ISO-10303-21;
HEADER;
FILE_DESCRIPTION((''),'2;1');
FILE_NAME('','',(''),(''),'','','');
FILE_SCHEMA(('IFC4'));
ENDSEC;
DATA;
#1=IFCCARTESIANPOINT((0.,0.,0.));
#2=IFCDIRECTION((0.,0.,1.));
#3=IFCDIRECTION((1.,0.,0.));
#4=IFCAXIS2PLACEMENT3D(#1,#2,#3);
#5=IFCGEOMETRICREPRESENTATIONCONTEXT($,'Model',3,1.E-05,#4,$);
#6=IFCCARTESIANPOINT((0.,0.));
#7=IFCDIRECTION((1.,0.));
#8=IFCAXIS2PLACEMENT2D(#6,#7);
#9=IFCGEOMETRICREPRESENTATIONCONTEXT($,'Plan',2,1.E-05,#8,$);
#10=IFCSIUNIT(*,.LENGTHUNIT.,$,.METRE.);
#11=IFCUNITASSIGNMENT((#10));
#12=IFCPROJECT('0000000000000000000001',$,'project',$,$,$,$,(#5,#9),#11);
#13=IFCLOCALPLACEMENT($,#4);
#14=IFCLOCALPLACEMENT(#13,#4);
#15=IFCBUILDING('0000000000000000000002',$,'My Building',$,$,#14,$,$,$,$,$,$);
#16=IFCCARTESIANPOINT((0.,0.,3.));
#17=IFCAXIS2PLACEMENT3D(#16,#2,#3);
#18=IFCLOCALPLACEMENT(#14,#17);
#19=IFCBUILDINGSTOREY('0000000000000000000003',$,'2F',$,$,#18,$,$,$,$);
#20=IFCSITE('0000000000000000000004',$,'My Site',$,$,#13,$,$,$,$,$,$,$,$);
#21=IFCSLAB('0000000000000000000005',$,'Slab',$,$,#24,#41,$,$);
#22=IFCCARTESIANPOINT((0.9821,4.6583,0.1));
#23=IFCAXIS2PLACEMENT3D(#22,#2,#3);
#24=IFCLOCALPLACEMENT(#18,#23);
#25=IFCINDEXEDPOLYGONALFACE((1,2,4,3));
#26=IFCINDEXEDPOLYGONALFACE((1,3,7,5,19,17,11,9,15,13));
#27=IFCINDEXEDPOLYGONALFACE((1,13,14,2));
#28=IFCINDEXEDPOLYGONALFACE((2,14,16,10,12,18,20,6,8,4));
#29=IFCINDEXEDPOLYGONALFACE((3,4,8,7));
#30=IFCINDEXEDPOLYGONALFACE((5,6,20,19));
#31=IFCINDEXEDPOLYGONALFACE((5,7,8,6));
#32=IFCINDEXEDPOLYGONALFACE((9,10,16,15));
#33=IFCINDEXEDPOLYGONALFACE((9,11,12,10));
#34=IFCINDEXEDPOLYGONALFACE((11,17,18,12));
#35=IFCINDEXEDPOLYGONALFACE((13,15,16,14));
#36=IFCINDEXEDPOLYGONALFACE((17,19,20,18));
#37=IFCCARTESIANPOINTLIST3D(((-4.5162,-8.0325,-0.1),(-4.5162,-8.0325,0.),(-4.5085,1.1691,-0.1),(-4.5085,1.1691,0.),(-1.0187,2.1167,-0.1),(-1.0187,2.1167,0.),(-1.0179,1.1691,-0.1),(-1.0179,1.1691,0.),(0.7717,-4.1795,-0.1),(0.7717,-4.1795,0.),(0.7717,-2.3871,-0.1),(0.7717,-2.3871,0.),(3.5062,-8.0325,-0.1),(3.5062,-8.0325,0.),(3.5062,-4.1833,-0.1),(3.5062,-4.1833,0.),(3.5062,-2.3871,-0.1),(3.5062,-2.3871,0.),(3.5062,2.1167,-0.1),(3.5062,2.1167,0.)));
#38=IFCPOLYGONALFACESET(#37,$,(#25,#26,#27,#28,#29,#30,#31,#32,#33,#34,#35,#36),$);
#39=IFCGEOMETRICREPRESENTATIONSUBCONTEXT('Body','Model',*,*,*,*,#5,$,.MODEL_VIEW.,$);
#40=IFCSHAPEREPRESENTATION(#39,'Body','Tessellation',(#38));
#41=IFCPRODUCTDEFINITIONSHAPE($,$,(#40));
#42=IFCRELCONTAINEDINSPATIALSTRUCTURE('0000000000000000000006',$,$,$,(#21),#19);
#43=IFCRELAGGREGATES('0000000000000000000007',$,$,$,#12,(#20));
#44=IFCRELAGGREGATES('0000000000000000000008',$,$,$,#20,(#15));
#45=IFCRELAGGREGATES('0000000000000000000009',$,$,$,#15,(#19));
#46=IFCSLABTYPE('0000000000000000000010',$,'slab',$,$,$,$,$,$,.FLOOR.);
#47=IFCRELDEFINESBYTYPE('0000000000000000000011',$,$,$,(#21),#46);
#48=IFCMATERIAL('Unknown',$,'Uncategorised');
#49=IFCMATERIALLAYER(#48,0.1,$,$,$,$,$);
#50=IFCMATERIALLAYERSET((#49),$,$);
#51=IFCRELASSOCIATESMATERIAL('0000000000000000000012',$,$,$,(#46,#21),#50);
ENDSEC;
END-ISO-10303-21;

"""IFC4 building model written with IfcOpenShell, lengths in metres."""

from ifc_helpers import new_model, si_unit, frame, origin_with_axes, origin_2d_with_axis, place, context, subcontext, project, spatial, indexed_curve, outline, extrude, material, layer, layer_set, layer_usage, type_object, element, save


model = new_model("IFC4")

# Units and contexts
model_context = context("Model", 3, precision=1e-05, world=origin_with_axes())
plan_context = context("Plan", 2, precision=1e-05, world=origin_2d_with_axis())
body_context_1 = subcontext(model_context, "Body", "Model", "MODEL_VIEW")
ifc_project = project(units=[si_unit("LENGTHUNIT", "METRE")], contexts=[model_context, plan_context])

# Site, building, storey
site_placement = place(None, origin_with_axes())
site = spatial("IfcSite", under=ifc_project, at=site_placement, Name="My Site")
building_placement = place(site_placement, origin_with_axes())
building = spatial("IfcBuilding", under=site, at=building_placement, Name="My Building")
storey_placement = place(building_placement, frame((0.0, 0.0, 3.0), z_axis=(0.0, 0.0, 1.0), x_axis=(1.0, 0.0, 0.0)))
storey = spatial("IfcBuildingStorey", under=building, at=storey_placement, Name="2F")

# Shared definitions
ifc_material = material(Name="Unknown", Category="Uncategorised")

# Slab
ifc_layer_1 = layer(ifc_material, 0.1)
ifc_layer_set_1 = layer_set([ifc_layer_1])
ifc_layer_usage_1 = layer_usage(ifc_layer_set_1, "AXIS3", "POSITIVE", -0.1)
slab_type = type_object("IfcSlabType", Name="slab", PredefinedType="FLOOR", material=ifc_layer_set_1)
slab_placement = place(storey_placement, frame((0.9821, 4.6583, 0.1), z_axis=(0.0, 0.0, 1.0), x_axis=(1.0, 0.0, 0.0)))
element("IfcSlab", 1, at=slab_placement, inside=storey, type_object=slab_type, material=ifc_layer_usage_1, Name="Slab", context=body_context_1, shape_type="SweptSolid", body=[
    extrude(outline(indexed_curve([(-1.0187, 2.1167), (-1.0179, 1.1691), (-4.5085, 1.1691), (-4.5162, -8.0325), (3.5062, -8.0325), (3.5062, -4.1833), (0.7717, -4.1795), (0.7717, -2.3871), (3.5062, -2.3871), (3.5062, 2.1167), (-1.0187, 2.1167)])), frame((0.0, 0.0, -0.1), z_axis=(0.0, 0.0, 1.0), x_axis=(1.0, 0.0, 0.0)), (0.0, 0.0, 1.0), 0.1),
])

save(model, "model.ifc")
